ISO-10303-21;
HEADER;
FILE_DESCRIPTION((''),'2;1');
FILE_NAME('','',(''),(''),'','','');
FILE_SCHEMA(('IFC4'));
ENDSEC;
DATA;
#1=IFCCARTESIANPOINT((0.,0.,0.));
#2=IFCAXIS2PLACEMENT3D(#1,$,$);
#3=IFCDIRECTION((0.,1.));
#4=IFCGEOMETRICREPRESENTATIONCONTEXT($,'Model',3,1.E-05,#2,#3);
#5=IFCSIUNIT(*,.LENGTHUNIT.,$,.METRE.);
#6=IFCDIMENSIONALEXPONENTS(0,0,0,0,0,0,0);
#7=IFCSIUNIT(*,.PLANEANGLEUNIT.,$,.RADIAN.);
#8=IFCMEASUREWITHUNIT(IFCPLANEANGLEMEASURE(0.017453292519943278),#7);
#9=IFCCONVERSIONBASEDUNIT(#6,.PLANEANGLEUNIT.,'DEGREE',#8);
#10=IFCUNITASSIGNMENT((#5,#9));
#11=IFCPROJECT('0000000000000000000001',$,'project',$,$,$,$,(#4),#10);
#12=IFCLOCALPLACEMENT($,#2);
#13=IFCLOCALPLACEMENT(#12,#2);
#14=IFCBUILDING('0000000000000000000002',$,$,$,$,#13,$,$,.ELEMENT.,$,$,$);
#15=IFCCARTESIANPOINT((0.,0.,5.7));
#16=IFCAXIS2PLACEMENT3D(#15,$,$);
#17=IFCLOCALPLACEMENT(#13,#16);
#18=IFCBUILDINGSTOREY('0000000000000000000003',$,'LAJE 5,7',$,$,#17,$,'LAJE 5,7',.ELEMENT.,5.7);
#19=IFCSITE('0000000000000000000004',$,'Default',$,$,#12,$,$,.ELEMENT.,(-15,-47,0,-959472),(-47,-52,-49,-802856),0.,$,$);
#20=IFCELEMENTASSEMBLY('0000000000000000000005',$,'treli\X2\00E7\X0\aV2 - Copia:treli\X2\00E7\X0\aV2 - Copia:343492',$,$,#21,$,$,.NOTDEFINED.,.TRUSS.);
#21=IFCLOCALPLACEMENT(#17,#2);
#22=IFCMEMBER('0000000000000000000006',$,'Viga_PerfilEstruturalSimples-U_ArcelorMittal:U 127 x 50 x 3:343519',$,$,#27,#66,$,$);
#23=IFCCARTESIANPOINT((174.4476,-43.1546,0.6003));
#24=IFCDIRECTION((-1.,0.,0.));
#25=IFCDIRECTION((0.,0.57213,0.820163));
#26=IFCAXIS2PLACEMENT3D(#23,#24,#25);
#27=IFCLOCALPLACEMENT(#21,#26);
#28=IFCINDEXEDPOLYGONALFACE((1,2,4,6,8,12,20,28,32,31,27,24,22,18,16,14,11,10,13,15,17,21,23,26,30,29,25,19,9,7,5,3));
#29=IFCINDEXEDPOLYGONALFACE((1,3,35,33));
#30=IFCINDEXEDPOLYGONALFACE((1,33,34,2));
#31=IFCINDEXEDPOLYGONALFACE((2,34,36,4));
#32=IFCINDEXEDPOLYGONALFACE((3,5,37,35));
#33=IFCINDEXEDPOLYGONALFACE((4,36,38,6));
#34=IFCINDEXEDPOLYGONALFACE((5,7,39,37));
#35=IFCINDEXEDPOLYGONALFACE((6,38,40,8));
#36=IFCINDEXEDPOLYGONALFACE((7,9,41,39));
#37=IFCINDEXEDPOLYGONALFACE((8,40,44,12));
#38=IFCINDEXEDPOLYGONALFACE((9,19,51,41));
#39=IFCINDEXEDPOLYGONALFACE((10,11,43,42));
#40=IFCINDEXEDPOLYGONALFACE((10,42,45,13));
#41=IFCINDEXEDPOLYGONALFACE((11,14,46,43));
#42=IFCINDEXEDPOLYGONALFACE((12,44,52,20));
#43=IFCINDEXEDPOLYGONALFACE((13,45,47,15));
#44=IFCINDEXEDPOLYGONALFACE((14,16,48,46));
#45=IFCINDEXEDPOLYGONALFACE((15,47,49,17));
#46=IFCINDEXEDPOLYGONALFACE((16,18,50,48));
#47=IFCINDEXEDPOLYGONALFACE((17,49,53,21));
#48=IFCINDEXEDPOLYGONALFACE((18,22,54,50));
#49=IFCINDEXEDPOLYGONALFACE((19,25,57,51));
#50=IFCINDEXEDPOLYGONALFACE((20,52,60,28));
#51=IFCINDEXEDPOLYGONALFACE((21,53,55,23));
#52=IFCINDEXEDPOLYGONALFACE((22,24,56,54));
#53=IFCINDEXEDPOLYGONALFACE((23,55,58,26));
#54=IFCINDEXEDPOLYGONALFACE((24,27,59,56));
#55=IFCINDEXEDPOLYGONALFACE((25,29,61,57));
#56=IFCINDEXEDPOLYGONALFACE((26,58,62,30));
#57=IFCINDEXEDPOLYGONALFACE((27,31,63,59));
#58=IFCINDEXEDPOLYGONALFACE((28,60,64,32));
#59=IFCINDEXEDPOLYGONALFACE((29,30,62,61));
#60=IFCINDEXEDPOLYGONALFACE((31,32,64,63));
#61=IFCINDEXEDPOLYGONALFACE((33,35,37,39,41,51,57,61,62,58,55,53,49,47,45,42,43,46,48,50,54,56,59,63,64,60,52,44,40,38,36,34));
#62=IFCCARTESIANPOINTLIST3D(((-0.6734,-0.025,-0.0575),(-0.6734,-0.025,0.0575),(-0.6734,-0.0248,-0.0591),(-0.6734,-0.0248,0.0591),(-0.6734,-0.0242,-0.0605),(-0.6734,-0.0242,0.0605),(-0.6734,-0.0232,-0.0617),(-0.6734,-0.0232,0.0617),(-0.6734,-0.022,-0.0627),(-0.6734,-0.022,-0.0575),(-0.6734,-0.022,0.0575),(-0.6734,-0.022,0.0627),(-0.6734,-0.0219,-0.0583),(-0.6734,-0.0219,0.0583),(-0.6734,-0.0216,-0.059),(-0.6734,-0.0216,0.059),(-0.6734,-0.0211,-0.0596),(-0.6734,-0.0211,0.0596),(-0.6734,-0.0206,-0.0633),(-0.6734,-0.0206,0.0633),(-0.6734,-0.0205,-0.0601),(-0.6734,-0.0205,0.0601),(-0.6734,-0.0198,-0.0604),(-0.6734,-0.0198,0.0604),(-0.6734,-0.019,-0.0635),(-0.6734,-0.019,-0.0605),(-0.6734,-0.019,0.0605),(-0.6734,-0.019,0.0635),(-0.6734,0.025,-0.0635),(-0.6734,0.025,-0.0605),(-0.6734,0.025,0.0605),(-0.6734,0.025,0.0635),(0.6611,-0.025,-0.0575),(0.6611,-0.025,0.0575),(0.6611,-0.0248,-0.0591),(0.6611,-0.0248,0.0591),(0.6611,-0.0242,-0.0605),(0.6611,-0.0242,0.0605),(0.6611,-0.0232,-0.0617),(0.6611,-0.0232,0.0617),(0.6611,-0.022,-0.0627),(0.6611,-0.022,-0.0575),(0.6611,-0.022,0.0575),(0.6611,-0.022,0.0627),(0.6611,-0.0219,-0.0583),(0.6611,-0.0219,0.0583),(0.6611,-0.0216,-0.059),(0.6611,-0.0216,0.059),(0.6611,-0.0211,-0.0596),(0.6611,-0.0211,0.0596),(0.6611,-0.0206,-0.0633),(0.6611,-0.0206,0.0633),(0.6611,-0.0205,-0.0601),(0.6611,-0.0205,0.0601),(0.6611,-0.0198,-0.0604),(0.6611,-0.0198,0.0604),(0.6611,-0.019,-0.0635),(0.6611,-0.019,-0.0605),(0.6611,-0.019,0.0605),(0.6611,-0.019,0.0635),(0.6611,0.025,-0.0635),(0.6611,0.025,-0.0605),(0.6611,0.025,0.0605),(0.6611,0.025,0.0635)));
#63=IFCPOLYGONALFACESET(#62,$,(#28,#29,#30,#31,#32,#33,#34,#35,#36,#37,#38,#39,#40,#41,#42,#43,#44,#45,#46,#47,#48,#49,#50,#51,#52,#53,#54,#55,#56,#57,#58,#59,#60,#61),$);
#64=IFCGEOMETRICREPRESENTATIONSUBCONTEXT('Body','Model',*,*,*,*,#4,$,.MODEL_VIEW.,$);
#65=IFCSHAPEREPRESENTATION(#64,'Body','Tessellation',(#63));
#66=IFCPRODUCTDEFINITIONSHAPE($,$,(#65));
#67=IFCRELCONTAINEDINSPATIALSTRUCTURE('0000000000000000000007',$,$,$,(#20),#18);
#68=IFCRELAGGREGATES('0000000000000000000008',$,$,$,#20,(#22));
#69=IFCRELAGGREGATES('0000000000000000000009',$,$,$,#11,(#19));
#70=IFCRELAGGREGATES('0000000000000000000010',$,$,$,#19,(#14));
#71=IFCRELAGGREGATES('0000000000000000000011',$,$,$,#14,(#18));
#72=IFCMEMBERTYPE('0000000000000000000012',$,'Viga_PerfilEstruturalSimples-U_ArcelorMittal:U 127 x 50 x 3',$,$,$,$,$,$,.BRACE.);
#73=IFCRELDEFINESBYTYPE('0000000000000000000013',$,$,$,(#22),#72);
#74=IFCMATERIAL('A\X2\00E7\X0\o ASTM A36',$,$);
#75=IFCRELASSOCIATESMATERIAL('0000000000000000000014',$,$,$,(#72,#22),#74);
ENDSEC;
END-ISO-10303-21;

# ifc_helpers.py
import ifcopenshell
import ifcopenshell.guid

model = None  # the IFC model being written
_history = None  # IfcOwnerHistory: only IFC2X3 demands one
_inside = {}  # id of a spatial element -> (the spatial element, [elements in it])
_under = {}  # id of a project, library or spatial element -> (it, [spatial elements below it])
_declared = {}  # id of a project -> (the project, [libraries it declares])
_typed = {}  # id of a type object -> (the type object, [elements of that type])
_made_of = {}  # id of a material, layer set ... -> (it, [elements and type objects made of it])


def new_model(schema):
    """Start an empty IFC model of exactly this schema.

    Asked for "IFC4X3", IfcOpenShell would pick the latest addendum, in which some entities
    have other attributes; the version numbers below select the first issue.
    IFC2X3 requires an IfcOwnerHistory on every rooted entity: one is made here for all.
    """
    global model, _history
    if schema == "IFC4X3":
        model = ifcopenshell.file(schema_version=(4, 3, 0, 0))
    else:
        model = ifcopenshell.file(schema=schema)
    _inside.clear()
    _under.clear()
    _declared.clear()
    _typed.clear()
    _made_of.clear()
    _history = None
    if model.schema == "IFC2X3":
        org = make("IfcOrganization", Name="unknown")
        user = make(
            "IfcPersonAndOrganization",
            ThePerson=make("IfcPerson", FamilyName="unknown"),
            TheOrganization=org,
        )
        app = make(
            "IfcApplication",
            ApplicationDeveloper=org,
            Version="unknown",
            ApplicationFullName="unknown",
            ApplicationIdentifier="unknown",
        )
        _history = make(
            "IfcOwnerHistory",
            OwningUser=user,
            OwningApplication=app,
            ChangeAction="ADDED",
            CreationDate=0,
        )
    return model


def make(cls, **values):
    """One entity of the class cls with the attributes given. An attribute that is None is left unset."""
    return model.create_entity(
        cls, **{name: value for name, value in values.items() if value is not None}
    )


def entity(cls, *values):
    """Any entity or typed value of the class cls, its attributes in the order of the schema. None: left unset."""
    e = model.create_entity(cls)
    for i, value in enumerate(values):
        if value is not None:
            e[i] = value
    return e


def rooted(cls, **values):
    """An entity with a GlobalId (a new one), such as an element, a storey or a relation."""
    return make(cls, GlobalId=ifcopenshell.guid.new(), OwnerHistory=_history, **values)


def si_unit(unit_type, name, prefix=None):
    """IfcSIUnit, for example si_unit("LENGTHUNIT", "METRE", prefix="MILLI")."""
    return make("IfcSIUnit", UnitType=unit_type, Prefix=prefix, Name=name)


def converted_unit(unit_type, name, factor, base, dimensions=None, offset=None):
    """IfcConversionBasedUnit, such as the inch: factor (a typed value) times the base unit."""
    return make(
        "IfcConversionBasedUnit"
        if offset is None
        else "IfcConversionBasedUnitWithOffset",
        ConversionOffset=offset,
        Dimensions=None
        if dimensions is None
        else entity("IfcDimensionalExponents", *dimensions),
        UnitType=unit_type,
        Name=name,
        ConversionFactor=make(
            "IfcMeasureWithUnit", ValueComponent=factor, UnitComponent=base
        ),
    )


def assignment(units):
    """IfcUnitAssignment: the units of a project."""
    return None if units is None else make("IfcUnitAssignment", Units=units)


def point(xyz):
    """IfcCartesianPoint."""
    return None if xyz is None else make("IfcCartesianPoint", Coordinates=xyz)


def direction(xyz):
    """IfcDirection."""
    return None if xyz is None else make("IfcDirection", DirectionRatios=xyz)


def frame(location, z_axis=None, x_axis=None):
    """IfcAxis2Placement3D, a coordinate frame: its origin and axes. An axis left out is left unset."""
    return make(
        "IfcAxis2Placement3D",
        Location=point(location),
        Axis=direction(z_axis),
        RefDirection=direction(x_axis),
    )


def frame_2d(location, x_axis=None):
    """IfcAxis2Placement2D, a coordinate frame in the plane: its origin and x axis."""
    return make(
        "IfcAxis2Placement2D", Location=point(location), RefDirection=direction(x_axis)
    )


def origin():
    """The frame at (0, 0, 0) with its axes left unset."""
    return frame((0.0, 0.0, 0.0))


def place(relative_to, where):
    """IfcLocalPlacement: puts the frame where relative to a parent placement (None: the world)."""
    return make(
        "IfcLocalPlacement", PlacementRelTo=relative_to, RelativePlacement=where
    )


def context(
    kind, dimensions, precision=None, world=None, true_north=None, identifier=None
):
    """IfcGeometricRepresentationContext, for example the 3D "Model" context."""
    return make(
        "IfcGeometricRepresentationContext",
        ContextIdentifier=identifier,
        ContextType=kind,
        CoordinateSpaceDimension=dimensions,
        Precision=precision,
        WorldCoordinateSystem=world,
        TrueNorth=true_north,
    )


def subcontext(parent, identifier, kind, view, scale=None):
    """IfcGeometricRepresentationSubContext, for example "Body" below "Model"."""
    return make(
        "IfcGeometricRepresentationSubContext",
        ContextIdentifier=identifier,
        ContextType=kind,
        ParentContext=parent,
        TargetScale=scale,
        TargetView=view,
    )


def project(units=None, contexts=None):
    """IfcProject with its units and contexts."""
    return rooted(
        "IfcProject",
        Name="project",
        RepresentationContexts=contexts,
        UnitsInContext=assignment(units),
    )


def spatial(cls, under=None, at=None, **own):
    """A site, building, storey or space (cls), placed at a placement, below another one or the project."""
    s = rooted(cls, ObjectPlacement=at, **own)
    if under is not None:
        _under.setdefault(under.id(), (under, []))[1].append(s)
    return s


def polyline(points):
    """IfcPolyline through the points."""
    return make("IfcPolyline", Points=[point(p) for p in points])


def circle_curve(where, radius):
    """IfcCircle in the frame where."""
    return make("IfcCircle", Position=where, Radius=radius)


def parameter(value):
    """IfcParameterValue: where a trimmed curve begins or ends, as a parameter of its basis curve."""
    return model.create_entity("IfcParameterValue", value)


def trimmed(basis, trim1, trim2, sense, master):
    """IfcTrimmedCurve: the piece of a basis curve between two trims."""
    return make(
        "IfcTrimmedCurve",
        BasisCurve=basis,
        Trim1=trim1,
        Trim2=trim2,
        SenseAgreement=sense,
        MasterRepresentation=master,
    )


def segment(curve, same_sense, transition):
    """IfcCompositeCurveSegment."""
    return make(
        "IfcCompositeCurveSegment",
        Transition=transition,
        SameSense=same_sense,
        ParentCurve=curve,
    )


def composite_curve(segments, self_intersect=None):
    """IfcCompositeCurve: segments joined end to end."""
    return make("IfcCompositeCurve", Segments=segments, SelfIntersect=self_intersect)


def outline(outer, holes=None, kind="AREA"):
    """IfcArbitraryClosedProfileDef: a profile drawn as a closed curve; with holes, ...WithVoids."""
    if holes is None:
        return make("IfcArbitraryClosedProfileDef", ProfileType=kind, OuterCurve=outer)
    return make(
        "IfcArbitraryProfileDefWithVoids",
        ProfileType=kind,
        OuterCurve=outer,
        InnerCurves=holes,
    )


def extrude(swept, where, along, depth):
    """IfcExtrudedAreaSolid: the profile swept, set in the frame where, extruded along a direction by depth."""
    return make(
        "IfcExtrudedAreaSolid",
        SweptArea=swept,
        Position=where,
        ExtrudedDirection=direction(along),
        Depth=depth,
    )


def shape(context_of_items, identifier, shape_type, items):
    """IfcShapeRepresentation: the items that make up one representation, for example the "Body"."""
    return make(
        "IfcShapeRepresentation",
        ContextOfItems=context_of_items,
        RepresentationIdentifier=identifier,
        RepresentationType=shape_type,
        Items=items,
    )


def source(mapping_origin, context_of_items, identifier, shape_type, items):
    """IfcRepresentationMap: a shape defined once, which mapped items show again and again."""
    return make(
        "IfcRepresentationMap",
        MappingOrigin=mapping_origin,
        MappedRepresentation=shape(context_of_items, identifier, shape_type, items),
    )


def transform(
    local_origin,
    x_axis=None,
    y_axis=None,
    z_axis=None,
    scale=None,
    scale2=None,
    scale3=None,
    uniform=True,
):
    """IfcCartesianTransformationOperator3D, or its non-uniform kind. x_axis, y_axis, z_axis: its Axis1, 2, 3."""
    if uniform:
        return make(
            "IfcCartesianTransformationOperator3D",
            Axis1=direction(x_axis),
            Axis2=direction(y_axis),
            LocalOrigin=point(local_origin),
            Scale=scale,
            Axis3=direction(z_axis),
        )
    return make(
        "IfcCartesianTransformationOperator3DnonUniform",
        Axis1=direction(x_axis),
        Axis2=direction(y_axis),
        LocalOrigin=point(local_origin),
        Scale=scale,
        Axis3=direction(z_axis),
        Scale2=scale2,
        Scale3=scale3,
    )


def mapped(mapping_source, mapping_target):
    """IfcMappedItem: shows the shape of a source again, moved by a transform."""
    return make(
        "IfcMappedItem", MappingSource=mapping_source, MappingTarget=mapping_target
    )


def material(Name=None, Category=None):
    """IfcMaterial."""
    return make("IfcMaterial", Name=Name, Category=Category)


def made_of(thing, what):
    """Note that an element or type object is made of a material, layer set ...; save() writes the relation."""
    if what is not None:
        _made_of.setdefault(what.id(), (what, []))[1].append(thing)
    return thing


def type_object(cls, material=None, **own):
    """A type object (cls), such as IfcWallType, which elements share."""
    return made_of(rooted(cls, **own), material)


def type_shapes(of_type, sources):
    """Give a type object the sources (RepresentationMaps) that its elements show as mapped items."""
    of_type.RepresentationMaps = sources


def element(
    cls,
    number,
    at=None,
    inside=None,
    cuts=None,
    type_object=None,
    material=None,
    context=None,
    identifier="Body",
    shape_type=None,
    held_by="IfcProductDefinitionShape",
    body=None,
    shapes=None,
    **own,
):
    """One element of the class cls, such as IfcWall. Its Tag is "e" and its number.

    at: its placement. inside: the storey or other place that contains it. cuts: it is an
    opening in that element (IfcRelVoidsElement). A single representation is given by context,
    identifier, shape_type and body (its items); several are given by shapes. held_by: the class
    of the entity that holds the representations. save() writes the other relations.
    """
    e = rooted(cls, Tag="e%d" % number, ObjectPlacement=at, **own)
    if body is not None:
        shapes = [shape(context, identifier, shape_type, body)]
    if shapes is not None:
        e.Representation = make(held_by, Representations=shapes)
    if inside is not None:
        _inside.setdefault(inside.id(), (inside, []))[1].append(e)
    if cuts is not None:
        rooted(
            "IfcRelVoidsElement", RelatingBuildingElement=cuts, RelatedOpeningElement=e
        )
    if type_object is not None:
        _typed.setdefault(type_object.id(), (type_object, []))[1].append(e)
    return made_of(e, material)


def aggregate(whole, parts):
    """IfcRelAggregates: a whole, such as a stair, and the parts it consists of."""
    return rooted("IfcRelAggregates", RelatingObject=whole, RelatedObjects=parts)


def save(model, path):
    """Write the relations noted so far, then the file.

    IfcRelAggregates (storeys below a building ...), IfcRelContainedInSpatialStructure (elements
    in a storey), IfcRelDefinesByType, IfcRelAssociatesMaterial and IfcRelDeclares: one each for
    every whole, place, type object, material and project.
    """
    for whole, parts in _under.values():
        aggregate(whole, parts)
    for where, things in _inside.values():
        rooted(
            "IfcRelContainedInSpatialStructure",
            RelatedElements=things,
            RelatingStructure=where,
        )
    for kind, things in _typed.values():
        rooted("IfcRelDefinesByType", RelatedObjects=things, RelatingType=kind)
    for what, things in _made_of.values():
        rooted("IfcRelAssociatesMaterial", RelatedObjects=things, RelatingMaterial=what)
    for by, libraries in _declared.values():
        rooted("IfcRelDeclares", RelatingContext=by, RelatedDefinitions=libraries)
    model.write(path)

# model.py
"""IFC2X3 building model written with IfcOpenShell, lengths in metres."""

from ifc_helpers import new_model, entity, si_unit, converted_unit, direction, frame, frame_2d, origin, place, context, subcontext, project, spatial, polyline, circle_curve, parameter, trimmed, segment, composite_curve, outline, extrude, source, transform, mapped, material, type_object, type_shapes, element, aggregate, save


model = new_model("IFC2X3")

# Units and contexts
model_context = context("Model", 3, precision=1e-05, world=origin(), true_north=direction((0.0, 1.0)))
body_context = subcontext(model_context, "Body", "Model", "MODEL_VIEW")
ifc_project = project(units=[si_unit("LENGTHUNIT", "METRE"), converted_unit("PLANEANGLEUNIT", "DEGREE", entity("IfcPlaneAngleMeasure", 0.017453292519943278), si_unit("PLANEANGLEUNIT", "RADIAN"), dimensions=[0, 0, 0, 0, 0, 0, 0])], contexts=[model_context])

# Site, building, storey
site_placement = place(None, origin())
site = spatial("IfcSite", under=ifc_project, at=site_placement, Name="Default", CompositionType="ELEMENT", RefLatitude=(-15, -47, 0, -959472), RefLongitude=(-47, -52, -49, -802856), RefElevation=0.0)
building_placement = place(site_placement, origin())
building = spatial("IfcBuilding", under=site, at=building_placement, CompositionType="ELEMENT")
storey_placement = place(building_placement, frame((0.0, 0.0, 5.7)))
storey = spatial("IfcBuildingStorey", under=building, at=storey_placement, Name="LAJE 5,7", LongName="LAJE 5,7", CompositionType="ELEMENT", Elevation=5.7)

# Element assembly
assembly_1_placement = place(storey_placement, origin())
assembly_1 = element("IfcElementAssembly", 1, at=assembly_1_placement, inside=storey, Name="treliçaV2 - Copia:treliçaV2 - Copia:343492", AssemblyPlace="NOTDEFINED", PredefinedType="TRUSS")
ifc_material = material(Name="Aço ASTM A36")

# Member
member_type_1 = type_object("IfcMemberType", Name="Viga_PerfilEstruturalSimples-U_ArcelorMittal:U 127 x 50 x 3", PredefinedType="BRACE", material=ifc_material)
shared_shape_1 = source(origin(), body_context, "Body", "SweptSolid", [
    extrude(outline(composite_curve([segment(polyline([(-0.0575, -0.0192), (0.0575, -0.0192)]), True, "CONTINUOUS"), segment(trimmed(circle_curve(frame_2d((0.0575, -0.0132), x_axis=(0.0, 1.0)), 0.006), [parameter(180.0)], [parameter(270.0)], True, "PARAMETER"), True, "CONTINUOUS"), segment(polyline([(0.0635, -0.0132), (0.0635, 0.0308)]), True, "CONTINUOUS"), segment(polyline([(0.0635, 0.0308), (0.0605, 0.0308)]), True, "CONTINUOUS"), segment(polyline([(0.0605, 0.0308), (0.0605, -0.0132)]), True, "CONTINUOUS"), segment(trimmed(circle_curve(frame_2d((0.0575, -0.0132), x_axis=(0.0, 1.0)), 0.003), [parameter(180.0)], [parameter(270.0)], True, "PARAMETER"), False, "CONTINUOUS"), segment(polyline([(0.0575, -0.0162), (-0.0575, -0.0162)]), True, "CONTINUOUS"), segment(trimmed(circle_curve(frame_2d((-0.0575, -0.0132), x_axis=(0.0, 1.0)), 0.003), [parameter(90.0)], [parameter(180.0)], True, "PARAMETER"), False, "CONTINUOUS"), segment(polyline([(-0.0605, -0.0132), (-0.0605, 0.0308)]), True, "CONTINUOUS"), segment(polyline([(-0.0605, 0.0308), (-0.0635, 0.0308)]), True, "CONTINUOUS"), segment(polyline([(-0.0635, 0.0308), (-0.0635, -0.0132)]), True, "CONTINUOUS"), segment(trimmed(circle_curve(frame_2d((-0.0575, -0.0132), x_axis=(0.0, 1.0)), 0.006), [parameter(90.0)], [parameter(180.0)], True, "PARAMETER"), True, "CONTINUOUS")], self_intersect=False)), frame((-0.6734, -0.0058, 0.0), z_axis=(1.0, 0.0, 0.0), x_axis=(0.0, 0.0, -1.0)), (0.0, 0.0, 1.0), 1.3345),
])
type_shapes(member_type_1, [shared_shape_1])
member_1_placement = place(assembly_1_placement, frame((174.4476, -43.1546, 0.6003), z_axis=(-1.0, 0.0, 0.0), x_axis=(0.0, 0.57213, 0.820163)))
member_1 = element("IfcMember", 2, at=member_1_placement, type_object=member_type_1, material=ifc_material, Name="Viga_PerfilEstruturalSimples-U_ArcelorMittal:U 127 x 50 x 3:343519", context=body_context, shape_type="MappedRepresentation", body=[
    mapped(shared_shape_1, transform((0.0, 0.0, 0.0), scale=1.0)),
])
aggregate(assembly_1, [member_1])

save(model, "model.ifc")
